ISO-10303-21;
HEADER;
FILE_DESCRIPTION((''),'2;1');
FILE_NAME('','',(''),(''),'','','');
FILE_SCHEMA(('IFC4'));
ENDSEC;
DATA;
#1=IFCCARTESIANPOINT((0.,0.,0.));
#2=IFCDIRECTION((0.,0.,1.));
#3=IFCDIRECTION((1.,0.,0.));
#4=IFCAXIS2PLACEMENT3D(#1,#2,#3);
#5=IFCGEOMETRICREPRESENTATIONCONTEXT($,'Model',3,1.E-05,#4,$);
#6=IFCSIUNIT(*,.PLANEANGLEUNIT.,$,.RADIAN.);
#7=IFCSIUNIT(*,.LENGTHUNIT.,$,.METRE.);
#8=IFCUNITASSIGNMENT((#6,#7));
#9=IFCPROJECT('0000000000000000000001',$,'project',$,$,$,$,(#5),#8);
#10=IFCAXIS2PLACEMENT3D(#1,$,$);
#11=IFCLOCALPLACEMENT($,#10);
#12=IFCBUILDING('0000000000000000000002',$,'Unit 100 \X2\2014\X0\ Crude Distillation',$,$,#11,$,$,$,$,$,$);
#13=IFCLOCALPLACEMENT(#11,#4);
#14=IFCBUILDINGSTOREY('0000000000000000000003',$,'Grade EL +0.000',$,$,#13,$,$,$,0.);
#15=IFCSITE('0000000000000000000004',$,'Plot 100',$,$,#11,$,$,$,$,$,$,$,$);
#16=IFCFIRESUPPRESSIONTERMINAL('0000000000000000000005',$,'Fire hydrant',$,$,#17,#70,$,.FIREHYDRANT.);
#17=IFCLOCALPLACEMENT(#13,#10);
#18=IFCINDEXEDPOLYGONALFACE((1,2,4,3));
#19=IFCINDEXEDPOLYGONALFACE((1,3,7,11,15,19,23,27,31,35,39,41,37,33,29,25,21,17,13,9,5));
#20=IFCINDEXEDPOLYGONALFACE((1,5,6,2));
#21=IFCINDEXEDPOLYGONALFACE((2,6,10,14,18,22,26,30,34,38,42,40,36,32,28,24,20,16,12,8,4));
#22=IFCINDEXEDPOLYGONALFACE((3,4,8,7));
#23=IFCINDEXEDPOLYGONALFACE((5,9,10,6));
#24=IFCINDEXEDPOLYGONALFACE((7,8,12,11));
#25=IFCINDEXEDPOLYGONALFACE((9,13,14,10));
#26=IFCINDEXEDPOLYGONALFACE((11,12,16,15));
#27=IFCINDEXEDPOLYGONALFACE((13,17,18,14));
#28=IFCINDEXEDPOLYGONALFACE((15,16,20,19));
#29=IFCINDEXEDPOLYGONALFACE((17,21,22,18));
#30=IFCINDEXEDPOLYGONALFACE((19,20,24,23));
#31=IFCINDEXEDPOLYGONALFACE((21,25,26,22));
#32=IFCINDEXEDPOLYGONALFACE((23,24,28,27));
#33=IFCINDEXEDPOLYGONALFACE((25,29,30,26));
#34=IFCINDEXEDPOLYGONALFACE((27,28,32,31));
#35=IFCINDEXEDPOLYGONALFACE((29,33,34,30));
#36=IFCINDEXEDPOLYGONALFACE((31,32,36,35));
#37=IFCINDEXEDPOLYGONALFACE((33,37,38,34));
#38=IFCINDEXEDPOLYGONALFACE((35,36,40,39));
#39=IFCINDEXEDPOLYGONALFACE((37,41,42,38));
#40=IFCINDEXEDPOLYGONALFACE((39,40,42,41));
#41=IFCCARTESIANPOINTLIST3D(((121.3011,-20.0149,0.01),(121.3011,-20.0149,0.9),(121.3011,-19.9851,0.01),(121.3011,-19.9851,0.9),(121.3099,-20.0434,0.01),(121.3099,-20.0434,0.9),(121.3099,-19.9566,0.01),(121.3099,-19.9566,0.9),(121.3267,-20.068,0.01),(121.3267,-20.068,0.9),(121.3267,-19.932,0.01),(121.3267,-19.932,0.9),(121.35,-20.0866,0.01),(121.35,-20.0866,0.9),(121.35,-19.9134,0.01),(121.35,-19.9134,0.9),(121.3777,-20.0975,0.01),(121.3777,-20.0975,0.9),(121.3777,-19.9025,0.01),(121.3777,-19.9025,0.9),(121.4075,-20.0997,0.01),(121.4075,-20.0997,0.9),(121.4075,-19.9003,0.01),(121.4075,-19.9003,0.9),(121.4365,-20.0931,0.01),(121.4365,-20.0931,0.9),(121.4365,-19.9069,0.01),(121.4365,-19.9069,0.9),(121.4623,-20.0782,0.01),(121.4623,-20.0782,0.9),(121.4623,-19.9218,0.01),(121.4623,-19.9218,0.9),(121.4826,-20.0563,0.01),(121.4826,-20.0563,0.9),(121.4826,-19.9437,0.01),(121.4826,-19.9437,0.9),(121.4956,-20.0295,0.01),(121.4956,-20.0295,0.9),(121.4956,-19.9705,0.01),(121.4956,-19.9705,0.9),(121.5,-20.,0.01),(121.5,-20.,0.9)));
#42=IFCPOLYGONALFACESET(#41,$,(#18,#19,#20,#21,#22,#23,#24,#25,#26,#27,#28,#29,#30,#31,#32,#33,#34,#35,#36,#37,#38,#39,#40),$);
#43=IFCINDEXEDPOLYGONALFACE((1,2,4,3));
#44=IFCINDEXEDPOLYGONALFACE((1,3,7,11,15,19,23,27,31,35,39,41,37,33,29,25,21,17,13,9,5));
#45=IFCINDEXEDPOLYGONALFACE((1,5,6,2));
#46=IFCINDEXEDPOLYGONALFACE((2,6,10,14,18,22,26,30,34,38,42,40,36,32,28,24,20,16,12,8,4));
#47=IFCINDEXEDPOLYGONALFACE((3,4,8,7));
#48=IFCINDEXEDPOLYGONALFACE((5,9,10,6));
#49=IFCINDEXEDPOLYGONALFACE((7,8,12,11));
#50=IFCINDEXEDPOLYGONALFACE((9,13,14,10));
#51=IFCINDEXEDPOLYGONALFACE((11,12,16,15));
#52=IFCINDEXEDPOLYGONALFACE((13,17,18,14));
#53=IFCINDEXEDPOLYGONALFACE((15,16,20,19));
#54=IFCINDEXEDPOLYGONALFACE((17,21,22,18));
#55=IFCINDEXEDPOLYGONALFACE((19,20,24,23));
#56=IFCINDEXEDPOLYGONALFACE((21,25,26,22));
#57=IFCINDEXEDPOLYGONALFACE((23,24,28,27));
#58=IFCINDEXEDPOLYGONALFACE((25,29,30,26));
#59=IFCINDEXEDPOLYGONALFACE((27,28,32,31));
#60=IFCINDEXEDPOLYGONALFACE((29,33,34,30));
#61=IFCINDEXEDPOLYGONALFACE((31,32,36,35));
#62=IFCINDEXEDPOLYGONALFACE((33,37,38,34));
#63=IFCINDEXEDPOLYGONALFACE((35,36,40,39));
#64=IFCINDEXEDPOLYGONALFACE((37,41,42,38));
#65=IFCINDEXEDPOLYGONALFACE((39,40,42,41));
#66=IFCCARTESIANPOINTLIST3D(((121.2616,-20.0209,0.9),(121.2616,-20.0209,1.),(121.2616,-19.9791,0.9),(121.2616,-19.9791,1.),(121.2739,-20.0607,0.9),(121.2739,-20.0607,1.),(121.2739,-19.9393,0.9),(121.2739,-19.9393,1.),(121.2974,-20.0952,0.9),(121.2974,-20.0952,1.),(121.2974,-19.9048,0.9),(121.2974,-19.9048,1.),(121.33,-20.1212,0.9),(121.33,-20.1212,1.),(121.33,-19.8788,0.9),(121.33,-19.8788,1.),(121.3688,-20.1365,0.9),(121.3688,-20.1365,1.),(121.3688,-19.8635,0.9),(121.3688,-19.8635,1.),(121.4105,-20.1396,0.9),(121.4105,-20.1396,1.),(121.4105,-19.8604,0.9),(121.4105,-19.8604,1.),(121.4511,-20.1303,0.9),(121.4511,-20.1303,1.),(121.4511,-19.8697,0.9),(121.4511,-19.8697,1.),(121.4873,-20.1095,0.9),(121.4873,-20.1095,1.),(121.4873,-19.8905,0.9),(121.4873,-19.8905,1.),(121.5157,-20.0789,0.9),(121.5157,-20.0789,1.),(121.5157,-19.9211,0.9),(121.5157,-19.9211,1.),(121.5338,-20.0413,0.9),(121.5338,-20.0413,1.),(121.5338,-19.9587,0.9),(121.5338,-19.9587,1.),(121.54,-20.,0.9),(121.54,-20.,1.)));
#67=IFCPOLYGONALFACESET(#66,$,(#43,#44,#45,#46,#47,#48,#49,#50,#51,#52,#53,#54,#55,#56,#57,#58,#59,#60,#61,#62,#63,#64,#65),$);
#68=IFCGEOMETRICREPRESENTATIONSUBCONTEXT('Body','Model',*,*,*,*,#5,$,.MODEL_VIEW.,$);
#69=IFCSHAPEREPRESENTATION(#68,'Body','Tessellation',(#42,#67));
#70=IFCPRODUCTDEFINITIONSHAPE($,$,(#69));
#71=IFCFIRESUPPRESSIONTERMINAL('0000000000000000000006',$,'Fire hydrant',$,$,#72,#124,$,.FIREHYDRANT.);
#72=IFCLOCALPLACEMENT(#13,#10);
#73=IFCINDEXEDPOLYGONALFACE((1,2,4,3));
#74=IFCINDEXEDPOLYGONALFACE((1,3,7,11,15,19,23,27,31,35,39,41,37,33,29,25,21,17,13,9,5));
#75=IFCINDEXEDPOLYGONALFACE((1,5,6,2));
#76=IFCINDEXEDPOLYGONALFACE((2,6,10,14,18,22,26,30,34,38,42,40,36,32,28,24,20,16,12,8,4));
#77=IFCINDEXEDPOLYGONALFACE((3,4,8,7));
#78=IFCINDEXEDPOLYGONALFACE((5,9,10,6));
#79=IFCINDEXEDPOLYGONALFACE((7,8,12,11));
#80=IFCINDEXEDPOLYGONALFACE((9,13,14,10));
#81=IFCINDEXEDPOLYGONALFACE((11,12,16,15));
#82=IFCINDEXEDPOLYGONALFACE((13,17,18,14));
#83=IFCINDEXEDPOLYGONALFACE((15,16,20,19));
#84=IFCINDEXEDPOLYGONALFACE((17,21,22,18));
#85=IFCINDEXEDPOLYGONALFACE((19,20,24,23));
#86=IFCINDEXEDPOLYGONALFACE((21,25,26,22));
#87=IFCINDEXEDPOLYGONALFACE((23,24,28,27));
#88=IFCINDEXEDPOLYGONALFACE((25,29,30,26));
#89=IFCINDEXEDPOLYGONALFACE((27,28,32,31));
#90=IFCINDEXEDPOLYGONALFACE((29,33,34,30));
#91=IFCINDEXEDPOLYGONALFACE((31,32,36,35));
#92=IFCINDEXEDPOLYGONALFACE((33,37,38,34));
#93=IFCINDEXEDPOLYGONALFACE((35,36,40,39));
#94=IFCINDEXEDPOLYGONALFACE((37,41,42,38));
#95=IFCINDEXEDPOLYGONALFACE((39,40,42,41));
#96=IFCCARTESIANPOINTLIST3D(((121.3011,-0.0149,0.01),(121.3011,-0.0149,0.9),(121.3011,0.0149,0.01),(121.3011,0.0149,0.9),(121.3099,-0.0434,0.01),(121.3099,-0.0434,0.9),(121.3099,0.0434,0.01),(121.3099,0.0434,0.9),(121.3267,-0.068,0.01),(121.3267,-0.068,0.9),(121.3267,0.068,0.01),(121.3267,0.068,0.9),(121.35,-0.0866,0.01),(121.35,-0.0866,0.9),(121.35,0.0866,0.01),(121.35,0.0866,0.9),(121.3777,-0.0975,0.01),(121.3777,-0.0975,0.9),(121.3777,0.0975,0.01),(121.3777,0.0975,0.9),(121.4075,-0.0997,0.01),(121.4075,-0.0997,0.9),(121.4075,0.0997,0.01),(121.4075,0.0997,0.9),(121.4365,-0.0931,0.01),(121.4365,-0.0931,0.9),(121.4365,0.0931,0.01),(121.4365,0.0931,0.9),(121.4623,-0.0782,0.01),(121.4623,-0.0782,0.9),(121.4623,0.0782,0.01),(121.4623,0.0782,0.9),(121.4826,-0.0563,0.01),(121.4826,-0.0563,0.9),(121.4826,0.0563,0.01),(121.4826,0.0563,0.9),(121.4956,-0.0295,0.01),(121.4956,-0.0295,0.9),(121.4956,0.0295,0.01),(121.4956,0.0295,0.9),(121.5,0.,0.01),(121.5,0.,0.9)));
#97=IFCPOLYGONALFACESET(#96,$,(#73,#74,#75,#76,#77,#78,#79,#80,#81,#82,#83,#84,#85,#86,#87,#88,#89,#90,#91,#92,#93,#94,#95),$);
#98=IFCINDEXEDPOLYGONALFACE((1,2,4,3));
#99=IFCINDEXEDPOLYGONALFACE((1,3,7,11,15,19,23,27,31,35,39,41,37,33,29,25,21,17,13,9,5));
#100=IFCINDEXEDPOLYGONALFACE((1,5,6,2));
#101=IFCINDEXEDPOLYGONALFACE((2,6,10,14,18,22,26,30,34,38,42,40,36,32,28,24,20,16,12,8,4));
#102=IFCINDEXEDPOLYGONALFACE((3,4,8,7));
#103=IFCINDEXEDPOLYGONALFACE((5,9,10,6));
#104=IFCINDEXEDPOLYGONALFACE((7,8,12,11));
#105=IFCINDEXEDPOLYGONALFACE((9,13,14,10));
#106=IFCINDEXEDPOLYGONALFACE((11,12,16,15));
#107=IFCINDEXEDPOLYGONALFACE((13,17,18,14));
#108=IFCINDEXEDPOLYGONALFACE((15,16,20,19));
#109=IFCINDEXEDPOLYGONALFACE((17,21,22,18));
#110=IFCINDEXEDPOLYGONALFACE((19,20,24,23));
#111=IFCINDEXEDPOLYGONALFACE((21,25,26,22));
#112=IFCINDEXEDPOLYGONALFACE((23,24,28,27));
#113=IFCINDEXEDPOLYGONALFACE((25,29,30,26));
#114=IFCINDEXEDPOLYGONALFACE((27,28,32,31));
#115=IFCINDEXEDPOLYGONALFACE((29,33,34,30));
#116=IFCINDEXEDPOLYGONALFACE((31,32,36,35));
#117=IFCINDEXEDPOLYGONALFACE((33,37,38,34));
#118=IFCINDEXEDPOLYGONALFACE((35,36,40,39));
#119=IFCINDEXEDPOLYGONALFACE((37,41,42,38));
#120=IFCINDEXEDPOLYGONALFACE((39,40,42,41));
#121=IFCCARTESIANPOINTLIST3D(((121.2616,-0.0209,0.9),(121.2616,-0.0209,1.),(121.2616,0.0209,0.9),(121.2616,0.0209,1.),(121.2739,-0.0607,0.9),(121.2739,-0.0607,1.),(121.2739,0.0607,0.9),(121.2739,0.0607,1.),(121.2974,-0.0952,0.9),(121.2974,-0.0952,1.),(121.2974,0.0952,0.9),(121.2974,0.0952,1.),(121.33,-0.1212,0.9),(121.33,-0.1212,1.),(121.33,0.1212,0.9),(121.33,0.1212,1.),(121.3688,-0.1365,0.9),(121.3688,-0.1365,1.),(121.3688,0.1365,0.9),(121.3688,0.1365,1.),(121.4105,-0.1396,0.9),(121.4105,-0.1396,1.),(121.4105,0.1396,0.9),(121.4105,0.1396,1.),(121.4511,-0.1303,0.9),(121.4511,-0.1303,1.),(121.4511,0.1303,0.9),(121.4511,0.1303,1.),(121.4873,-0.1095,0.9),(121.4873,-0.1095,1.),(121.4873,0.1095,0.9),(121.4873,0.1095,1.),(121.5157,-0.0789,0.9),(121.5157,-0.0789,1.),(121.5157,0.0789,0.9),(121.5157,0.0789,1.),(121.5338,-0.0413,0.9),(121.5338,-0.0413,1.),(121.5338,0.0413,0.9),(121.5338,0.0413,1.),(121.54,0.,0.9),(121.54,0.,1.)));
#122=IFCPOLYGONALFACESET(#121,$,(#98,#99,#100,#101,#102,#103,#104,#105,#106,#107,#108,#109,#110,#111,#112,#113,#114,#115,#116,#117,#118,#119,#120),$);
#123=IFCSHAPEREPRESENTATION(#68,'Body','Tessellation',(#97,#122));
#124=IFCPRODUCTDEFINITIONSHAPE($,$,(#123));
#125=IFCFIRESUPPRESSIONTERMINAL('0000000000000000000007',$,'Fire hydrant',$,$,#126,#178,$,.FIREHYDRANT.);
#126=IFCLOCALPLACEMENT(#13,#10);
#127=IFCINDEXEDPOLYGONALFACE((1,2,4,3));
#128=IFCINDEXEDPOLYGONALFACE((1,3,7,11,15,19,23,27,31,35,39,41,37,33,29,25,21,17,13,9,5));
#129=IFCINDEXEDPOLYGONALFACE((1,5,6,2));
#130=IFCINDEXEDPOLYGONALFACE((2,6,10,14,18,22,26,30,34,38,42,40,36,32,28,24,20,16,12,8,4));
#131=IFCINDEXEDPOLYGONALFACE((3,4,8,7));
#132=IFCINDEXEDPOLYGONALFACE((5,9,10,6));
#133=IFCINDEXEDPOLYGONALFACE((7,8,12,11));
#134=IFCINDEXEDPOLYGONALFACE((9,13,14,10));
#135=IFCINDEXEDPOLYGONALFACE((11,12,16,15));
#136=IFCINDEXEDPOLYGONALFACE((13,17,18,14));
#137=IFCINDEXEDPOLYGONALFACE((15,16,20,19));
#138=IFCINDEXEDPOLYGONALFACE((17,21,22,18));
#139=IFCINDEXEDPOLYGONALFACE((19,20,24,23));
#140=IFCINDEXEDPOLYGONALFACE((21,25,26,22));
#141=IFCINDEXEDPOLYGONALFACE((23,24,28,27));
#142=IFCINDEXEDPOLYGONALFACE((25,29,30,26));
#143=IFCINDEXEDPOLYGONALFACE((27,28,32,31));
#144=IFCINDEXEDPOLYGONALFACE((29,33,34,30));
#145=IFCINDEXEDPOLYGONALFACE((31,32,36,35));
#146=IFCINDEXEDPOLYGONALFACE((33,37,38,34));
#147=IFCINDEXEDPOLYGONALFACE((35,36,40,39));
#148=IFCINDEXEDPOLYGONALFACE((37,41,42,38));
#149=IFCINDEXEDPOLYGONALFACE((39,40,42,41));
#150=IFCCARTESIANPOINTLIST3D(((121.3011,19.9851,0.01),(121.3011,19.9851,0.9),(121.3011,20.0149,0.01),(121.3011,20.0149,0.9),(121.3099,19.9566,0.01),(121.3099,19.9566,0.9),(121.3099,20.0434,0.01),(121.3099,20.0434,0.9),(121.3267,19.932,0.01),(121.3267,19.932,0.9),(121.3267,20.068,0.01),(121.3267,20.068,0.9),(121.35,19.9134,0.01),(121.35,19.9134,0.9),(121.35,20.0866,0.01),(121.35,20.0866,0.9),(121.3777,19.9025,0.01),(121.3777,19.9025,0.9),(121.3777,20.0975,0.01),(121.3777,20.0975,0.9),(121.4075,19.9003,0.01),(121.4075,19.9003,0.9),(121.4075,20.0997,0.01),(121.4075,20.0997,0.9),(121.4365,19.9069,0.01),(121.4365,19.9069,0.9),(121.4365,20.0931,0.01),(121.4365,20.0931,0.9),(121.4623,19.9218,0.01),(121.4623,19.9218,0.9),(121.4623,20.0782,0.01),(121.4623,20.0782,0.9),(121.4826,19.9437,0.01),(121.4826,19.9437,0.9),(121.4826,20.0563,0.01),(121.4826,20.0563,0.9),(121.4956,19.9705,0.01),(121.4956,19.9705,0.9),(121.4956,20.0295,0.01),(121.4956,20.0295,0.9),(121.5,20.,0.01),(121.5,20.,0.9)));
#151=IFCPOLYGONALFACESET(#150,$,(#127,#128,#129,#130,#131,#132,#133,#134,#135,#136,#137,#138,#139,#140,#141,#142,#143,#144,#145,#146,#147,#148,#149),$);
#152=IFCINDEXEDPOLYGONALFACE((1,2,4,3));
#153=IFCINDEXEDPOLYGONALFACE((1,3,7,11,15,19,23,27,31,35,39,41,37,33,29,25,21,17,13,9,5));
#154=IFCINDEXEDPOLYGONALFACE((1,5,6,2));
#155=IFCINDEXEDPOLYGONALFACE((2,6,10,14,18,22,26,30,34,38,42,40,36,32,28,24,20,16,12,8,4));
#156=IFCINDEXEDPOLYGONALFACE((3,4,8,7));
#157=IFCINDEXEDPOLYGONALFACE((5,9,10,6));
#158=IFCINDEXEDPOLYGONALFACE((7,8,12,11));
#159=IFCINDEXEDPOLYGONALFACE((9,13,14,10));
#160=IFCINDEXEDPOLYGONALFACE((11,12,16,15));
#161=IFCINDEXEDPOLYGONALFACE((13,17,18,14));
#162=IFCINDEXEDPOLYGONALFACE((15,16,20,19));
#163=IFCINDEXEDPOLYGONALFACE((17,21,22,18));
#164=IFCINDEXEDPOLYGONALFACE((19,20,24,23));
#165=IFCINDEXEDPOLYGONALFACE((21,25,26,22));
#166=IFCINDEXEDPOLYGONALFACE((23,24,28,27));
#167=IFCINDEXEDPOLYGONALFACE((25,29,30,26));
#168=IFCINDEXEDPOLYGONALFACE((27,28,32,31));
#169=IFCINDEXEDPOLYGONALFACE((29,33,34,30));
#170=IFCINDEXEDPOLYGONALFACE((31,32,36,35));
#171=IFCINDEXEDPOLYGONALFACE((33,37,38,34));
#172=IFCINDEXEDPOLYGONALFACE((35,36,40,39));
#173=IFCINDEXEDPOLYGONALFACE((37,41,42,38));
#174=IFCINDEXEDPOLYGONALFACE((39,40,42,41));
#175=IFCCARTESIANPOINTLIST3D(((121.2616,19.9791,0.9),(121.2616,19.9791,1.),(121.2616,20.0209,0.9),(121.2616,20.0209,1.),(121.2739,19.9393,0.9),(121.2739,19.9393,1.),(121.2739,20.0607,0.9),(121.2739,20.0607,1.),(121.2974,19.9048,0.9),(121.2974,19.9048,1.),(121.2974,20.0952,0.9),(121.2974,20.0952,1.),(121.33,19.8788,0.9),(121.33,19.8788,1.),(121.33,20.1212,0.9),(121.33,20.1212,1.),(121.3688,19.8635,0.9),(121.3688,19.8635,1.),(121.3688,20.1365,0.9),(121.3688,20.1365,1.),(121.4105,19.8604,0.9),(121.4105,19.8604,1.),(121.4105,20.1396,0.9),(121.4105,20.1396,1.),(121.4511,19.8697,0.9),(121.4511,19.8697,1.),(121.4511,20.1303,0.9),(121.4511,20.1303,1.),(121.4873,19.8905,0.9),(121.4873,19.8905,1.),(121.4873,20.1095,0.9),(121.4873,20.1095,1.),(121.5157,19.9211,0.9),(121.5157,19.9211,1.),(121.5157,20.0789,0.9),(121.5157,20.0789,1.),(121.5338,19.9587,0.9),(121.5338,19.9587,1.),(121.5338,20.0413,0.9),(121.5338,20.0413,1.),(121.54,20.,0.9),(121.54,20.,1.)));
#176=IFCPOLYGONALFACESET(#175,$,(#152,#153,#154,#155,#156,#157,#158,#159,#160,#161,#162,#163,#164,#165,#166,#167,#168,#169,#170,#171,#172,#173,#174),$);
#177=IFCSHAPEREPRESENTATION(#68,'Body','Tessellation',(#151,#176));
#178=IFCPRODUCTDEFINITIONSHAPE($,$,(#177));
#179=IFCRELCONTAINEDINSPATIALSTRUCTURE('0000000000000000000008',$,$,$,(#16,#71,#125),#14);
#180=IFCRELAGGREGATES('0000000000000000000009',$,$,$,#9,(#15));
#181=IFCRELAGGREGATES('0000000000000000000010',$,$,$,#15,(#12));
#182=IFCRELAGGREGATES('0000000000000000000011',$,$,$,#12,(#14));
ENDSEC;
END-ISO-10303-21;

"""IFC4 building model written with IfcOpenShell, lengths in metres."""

from ifc_helpers import new_model, si_unit, frame, origin, origin_with_axes, origin_2d, place, context, subcontext, project, spatial, circle, extrude, element, save


model = new_model("IFC4")

# Units and contexts
model_context = context("Model", 3, precision=1e-05, world=origin_with_axes())
body_context = subcontext(model_context, "Body", "Model", "MODEL_VIEW")
ifc_project = project(units=[si_unit("PLANEANGLEUNIT", "RADIAN"), si_unit("LENGTHUNIT", "METRE")], contexts=[model_context])

# Site, building, storey
placement = place(None, origin())
site = spatial("IfcSite", under=ifc_project, at=placement, Name="Plot 100")
building = spatial("IfcBuilding", under=site, at=placement, Name="Unit 100 — Crude Distillation")
storey_placement = place(placement, origin_with_axes())
storey = spatial("IfcBuildingStorey", under=building, at=storey_placement, Name="Grade EL +0.000", Elevation=0.0)

# Fire suppression terminals
fire_suppression_terminal_1_placement = place(storey_placement, origin_with_axes())
element("IfcFireSuppressionTerminal", 1, at=fire_suppression_terminal_1_placement, inside=storey, Name="Fire hydrant", PredefinedType="FIREHYDRANT", context=body_context, shape_type="SweptSolid", body=[
    extrude(circle(Radius=0.1, at=origin_2d()), frame((121.4, -20.0, 0.01), z_axis=(0.0, 0.0, 1.0), x_axis=(1.0, 0.0, 0.0)), (0.0, 0.0, 1.0), 0.89),
    extrude(circle(Radius=0.14, at=origin_2d()), frame((121.4, -20.0, 0.9), z_axis=(0.0, 0.0, 1.0), x_axis=(1.0, 0.0, 0.0)), (0.0, 0.0, 1.0), 0.1),
])
fire_suppression_terminal_2_placement = place(storey_placement, origin_with_axes())
element("IfcFireSuppressionTerminal", 2, at=fire_suppression_terminal_2_placement, inside=storey, Name="Fire hydrant", PredefinedType="FIREHYDRANT", context=body_context, shape_type="SweptSolid", body=[
    extrude(circle(Radius=0.1, at=origin_2d()), frame((121.4, 0.0, 0.01), z_axis=(0.0, 0.0, 1.0), x_axis=(1.0, 0.0, 0.0)), (0.0, 0.0, 1.0), 0.89),
    extrude(circle(Radius=0.14, at=origin_2d()), frame((121.4, 0.0, 0.9), z_axis=(0.0, 0.0, 1.0), x_axis=(1.0, 0.0, 0.0)), (0.0, 0.0, 1.0), 0.1),
])
fire_suppression_terminal_3_placement = place(storey_placement, origin_with_axes())
element("IfcFireSuppressionTerminal", 3, at=fire_suppression_terminal_3_placement, inside=storey, Name="Fire hydrant", PredefinedType="FIREHYDRANT", context=body_context, shape_type="SweptSolid", body=[
    extrude(circle(Radius=0.1, at=origin_2d()), frame((121.4, 20.0, 0.01), z_axis=(0.0, 0.0, 1.0), x_axis=(1.0, 0.0, 0.0)), (0.0, 0.0, 1.0), 0.89),
    extrude(circle(Radius=0.14, at=origin_2d()), frame((121.4, 20.0, 0.9), z_axis=(0.0, 0.0, 1.0), x_axis=(1.0, 0.0, 0.0)), (0.0, 0.0, 1.0), 0.1),
])

save(model, "model.ifc")
